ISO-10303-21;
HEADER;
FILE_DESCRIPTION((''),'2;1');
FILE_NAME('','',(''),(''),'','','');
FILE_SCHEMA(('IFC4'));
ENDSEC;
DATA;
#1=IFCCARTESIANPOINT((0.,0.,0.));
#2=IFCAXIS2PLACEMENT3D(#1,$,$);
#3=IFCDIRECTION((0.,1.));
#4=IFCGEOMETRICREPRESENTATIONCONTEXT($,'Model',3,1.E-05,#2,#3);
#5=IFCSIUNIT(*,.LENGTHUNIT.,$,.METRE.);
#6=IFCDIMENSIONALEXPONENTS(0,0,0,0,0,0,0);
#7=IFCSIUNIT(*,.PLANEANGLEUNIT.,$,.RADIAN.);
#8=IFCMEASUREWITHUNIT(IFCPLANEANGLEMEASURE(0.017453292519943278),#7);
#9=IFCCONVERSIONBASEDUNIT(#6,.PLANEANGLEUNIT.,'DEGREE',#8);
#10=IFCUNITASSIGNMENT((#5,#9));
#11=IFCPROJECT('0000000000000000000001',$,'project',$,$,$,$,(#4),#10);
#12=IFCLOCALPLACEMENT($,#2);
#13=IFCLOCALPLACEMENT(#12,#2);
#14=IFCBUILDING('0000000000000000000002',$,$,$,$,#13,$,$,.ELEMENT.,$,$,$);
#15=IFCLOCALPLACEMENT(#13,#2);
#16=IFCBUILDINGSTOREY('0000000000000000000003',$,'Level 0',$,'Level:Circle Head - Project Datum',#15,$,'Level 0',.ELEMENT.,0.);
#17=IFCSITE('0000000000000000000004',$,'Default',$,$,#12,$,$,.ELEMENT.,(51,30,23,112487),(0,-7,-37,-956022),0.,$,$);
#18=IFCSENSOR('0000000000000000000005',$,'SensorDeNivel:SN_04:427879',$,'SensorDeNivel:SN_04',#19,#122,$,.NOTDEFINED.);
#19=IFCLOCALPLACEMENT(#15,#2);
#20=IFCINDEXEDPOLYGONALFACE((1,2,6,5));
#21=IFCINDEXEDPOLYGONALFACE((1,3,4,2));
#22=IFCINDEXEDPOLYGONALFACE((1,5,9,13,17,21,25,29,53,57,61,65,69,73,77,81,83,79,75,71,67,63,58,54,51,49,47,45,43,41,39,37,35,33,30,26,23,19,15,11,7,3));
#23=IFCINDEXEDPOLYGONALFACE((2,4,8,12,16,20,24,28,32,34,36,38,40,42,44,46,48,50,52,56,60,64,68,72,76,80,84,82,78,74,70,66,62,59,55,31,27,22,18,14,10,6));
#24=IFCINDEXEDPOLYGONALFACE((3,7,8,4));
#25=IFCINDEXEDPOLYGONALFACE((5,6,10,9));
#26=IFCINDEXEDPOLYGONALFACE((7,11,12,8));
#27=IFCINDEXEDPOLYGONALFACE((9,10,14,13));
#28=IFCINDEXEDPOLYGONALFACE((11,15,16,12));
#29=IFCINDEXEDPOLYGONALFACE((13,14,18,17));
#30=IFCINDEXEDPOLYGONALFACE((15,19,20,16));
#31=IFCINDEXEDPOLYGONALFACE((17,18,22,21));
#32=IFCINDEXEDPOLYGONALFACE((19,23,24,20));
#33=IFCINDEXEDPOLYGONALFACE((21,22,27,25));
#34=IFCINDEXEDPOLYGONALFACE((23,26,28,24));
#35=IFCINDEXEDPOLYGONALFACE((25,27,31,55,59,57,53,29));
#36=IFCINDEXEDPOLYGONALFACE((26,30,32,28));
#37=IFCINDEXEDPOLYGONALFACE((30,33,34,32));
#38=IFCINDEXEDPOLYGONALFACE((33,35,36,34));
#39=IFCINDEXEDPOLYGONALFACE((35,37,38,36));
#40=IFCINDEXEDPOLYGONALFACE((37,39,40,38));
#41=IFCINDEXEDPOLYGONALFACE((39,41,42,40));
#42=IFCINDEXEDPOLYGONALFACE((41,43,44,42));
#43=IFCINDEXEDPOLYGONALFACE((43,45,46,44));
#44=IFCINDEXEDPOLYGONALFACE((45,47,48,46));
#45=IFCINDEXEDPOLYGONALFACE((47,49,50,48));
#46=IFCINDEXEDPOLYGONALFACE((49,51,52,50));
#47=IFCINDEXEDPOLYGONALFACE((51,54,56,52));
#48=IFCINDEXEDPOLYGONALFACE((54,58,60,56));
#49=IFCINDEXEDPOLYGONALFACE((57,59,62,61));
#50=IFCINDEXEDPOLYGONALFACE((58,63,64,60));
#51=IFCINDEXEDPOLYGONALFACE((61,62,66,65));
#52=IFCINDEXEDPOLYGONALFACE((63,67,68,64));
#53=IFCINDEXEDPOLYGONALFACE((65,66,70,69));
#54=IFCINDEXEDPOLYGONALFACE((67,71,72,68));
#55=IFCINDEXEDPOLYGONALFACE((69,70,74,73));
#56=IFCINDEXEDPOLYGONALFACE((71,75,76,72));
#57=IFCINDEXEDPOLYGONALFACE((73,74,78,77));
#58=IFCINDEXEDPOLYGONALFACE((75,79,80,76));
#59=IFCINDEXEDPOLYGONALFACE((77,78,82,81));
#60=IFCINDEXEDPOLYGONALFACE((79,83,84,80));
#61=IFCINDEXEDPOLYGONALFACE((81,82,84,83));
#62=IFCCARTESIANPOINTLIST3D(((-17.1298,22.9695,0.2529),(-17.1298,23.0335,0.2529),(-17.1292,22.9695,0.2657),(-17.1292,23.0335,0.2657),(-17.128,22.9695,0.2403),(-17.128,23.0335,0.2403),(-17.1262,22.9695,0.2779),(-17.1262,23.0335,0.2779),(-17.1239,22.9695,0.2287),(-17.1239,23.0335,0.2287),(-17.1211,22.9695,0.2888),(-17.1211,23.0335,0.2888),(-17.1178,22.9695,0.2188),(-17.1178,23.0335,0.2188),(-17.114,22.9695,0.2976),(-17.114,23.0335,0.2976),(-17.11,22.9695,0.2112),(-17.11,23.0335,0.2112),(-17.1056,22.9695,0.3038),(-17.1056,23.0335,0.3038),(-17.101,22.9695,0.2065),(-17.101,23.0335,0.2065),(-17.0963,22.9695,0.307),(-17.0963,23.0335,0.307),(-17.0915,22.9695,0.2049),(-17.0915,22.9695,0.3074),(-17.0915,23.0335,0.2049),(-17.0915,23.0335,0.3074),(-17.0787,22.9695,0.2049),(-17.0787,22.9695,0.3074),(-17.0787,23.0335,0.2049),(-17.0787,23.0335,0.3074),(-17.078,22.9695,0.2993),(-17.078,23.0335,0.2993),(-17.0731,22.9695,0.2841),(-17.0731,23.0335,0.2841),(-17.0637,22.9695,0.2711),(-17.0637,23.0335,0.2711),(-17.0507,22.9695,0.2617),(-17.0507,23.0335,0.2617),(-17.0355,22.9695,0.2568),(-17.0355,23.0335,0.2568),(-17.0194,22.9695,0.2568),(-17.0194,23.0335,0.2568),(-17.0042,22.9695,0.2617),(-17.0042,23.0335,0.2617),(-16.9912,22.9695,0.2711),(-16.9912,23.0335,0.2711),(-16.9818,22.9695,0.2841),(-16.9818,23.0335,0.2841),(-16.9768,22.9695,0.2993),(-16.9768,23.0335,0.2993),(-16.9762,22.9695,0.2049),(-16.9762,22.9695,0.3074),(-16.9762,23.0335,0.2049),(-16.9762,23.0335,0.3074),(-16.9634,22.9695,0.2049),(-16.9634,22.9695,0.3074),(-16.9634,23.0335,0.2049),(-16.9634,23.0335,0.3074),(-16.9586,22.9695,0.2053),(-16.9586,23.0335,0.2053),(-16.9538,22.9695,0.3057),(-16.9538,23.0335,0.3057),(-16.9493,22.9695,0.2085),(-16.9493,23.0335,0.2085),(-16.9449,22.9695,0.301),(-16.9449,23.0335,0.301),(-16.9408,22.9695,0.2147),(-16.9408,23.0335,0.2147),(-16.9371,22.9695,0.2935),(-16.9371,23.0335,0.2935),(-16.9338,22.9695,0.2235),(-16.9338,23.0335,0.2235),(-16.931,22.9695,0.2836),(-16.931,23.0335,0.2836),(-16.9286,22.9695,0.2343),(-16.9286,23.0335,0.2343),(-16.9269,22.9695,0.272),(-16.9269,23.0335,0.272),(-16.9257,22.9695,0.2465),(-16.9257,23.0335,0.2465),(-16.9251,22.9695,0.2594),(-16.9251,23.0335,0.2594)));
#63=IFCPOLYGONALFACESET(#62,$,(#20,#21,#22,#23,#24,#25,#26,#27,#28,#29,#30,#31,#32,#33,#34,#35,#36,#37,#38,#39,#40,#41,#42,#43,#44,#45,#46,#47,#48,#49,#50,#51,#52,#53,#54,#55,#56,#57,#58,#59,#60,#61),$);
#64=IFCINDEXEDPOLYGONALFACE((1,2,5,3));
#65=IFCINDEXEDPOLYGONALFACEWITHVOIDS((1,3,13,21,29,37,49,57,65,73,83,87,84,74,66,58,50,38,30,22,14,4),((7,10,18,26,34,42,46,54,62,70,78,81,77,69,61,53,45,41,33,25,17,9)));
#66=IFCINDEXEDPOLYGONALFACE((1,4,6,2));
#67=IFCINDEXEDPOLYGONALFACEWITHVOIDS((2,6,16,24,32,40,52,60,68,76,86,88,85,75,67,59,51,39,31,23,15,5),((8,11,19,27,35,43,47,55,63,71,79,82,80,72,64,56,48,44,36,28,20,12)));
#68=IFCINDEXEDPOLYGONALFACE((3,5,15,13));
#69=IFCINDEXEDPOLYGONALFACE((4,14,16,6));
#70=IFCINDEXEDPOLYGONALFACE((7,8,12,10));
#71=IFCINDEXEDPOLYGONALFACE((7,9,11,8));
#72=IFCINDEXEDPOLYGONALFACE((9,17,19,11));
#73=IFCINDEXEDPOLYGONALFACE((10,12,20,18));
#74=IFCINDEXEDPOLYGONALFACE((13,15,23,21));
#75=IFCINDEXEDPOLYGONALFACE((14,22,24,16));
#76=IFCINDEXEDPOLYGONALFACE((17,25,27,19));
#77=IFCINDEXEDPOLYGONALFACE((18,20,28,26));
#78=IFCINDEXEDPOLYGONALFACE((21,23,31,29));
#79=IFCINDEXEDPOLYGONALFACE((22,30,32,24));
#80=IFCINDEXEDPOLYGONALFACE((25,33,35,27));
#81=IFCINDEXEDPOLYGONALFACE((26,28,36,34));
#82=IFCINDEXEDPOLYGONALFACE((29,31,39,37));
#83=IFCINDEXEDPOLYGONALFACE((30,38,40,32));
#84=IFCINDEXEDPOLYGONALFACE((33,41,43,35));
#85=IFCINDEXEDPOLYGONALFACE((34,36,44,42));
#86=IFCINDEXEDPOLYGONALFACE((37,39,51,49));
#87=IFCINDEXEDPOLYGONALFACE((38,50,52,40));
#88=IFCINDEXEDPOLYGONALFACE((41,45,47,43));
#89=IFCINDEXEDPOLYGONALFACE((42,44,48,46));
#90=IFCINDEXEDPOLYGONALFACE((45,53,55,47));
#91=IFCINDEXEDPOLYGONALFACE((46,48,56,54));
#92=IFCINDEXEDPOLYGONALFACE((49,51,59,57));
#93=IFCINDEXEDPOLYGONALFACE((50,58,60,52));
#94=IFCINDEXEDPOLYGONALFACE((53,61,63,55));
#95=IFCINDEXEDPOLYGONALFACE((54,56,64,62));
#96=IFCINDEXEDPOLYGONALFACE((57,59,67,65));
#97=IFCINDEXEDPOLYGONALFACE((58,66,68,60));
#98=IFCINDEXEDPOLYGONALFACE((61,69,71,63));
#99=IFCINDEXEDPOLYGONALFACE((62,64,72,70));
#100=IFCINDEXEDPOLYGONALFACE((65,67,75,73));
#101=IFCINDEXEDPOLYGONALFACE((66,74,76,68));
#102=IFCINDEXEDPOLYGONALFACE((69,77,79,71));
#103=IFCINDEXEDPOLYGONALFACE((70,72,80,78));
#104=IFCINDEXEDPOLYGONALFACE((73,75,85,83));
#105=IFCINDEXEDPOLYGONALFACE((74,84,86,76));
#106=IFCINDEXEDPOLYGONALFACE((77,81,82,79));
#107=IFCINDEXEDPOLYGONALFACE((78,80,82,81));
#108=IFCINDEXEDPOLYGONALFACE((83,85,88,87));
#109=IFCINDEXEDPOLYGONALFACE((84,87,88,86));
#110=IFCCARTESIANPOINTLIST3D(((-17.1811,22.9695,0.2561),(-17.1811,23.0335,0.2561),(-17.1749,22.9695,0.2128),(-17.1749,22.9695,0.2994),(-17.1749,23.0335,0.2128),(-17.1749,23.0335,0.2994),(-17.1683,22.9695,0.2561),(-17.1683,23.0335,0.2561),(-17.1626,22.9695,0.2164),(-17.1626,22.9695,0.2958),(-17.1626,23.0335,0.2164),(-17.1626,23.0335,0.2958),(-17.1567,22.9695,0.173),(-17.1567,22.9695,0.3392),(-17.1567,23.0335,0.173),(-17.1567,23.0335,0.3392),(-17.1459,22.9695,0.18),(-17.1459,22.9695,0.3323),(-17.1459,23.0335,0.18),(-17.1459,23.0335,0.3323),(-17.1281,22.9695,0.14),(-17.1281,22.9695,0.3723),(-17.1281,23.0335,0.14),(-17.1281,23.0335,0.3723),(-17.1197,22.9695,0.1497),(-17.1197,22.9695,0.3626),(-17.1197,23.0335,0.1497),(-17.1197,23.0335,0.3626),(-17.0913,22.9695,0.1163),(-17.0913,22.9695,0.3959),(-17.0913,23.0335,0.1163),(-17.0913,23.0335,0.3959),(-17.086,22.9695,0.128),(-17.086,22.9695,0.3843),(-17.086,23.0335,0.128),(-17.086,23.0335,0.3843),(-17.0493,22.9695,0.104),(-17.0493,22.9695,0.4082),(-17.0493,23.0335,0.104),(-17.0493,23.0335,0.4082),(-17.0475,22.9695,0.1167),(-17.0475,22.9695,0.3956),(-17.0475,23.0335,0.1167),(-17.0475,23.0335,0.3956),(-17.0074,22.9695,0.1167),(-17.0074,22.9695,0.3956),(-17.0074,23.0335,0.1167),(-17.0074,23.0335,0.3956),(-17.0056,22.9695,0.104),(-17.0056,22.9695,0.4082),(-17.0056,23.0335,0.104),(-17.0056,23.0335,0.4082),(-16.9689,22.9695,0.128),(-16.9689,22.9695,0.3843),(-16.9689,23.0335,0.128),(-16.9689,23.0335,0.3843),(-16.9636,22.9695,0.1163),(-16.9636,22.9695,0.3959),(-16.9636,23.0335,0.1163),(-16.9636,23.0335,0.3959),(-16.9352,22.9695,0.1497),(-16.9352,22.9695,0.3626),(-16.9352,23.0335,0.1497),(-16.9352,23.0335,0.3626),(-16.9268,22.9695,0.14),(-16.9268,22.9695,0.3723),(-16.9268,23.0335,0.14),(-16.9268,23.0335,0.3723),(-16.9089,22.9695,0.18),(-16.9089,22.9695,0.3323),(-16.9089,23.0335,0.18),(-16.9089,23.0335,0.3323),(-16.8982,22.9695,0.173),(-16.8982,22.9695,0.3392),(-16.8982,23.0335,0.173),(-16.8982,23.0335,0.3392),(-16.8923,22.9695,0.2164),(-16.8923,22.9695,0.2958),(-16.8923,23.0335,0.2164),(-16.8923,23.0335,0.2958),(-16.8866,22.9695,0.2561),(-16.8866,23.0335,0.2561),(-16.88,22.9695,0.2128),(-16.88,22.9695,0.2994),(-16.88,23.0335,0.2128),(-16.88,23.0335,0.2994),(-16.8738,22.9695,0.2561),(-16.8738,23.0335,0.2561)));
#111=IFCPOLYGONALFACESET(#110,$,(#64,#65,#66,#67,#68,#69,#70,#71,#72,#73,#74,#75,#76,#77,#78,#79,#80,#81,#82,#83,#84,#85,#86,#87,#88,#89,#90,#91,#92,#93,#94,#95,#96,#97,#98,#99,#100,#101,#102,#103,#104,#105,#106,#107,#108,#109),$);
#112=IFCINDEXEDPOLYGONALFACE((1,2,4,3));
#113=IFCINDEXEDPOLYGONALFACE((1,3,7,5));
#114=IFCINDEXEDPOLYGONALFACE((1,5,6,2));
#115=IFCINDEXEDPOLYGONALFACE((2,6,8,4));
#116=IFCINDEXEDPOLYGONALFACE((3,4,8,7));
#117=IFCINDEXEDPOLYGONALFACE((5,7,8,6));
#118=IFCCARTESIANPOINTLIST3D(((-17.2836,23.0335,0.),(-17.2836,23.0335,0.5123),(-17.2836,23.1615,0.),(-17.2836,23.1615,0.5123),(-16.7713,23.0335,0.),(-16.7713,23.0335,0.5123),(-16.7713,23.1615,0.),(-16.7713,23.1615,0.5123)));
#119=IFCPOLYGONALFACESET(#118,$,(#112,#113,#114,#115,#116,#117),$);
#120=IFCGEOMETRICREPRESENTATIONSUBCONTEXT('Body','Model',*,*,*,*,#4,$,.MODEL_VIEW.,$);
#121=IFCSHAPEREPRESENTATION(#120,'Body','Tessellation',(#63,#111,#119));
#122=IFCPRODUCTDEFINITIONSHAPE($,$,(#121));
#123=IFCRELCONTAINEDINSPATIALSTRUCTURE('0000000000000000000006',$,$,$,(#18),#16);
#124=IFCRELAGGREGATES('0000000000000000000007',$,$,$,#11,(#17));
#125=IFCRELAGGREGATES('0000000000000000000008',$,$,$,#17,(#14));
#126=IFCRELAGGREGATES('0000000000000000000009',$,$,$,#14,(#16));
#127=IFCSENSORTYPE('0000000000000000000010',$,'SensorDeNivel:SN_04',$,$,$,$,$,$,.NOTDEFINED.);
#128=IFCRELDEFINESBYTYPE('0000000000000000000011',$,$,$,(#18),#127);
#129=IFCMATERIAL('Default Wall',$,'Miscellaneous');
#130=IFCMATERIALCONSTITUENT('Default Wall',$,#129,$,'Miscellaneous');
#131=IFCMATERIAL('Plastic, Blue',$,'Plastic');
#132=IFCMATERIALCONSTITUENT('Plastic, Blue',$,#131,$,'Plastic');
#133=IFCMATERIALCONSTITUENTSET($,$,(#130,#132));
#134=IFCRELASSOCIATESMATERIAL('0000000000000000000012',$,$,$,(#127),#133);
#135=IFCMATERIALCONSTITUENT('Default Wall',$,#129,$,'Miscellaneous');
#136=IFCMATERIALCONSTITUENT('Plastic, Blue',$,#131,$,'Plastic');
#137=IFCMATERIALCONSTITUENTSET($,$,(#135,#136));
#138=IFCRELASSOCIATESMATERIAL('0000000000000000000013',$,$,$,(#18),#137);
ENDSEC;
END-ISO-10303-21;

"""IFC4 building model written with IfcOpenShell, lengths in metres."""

from ifc_helpers import new_model, entity, si_unit, converted_unit, direction, frame, origin, place, context, subcontext, project, spatial, arc, indexed_curve, outline, extrude, source, transform, mapped, material, constituent, constituent_set, type_object, type_shapes, element, save


model = new_model("IFC4")

# Units and contexts
model_context = context("Model", 3, precision=1e-05, world=origin(), true_north=direction((0.0, 1.0)))
body_context = subcontext(model_context, "Body", "Model", "MODEL_VIEW")
ifc_project = project(units=[si_unit("LENGTHUNIT", "METRE"), converted_unit("PLANEANGLEUNIT", "DEGREE", entity("IfcPlaneAngleMeasure", 0.017453292519943278), si_unit("PLANEANGLEUNIT", "RADIAN"), dimensions=[0, 0, 0, 0, 0, 0, 0])], contexts=[model_context])

# Site, building, storey
site_placement = place(None, origin())
site = spatial("IfcSite", under=ifc_project, at=site_placement, Name="Default", CompositionType="ELEMENT", RefLatitude=(51, 30, 23, 112487), RefLongitude=(0, -7, -37, -956022), RefElevation=0.0)
building_placement = place(site_placement, origin())
building = spatial("IfcBuilding", under=site, at=building_placement, CompositionType="ELEMENT")
storey_placement = place(building_placement, origin())
storey = spatial("IfcBuildingStorey", under=building, at=storey_placement, Name="Level 0", ObjectType="Level:Circle Head - Project Datum", LongName="Level 0", CompositionType="ELEMENT", Elevation=0.0)

# Sensor
ifc_material_1 = material(Name="Default Wall", Category="Miscellaneous")
ifc_material_2 = material(Name="Plastic, Blue", Category="Plastic")
ifc_constituent_1 = constituent(ifc_material_1, Name="Default Wall", Category="Miscellaneous")
ifc_constituent_2 = constituent(ifc_material_2, Name="Plastic, Blue", Category="Plastic")
ifc_constituent_set_1 = constituent_set(constituents=[ifc_constituent_1, ifc_constituent_2])
ifc_constituent_3 = constituent(ifc_material_1, Name="Default Wall", Category="Miscellaneous")
ifc_constituent_4 = constituent(ifc_material_2, Name="Plastic, Blue", Category="Plastic")
ifc_constituent_set_2 = constituent_set(constituents=[ifc_constituent_3, ifc_constituent_4])
sensor_type_1 = type_object("IfcSensorType", Name="SensorDeNivel:SN_04", PredefinedType="NOTDEFINED", material=ifc_constituent_set_2)
shared_shape_1 = source(origin(), body_context, "Body", "SweptSolid", [
    extrude(outline(indexed_curve([(0.0512, -0.0556), (0.064, -0.0556), (0.0736, -0.054), (0.0825, -0.0493), (0.0903, -0.0417), (0.0965, -0.0318), (0.1006, -0.0202), (0.1024, -0.0076), (0.1018, 0.0052), (0.0988, 0.0174), (0.0936, 0.0283), (0.0866, 0.037), (0.0782, 0.0432), (0.0689, 0.0464), (0.064, 0.0468), (0.0512, 0.0468), (0.0506, 0.0388), (0.0456, 0.0236), (0.0362, 0.0106), (0.0233, 0.0012), (0.008, -0.0038), (-0.008, -0.0038), (-0.0233, 0.0012), (-0.0362, 0.0106), (-0.0456, 0.0236), (-0.0506, 0.0388), (-0.0512, 0.0468), (-0.064, 0.0468), (-0.0736, 0.0452), (-0.0825, 0.0405), (-0.0903, 0.0329), (-0.0965, 0.023), (-0.1006, 0.0114), (-0.1024, -0.0012), (-0.1018, -0.014), (-0.0988, -0.0262), (-0.0936, -0.0371), (-0.0866, -0.0458), (-0.0782, -0.052), (-0.0689, -0.0552), (-0.064, -0.0556), (-0.0512, -0.0556), (0.0512, -0.0556)], self_intersect=False)), frame((0.0, -0.1281, 0.2605), z_axis=(0.0, 1.0, 0.0), x_axis=(-1.0, 0.0, 0.0)), (0.0, 0.0, 1.0), 0.064),
    extrude(outline(indexed_curve([(-0.1537, 0.0), (0.0, -0.1537), (0.1537, 0.0), (0.0, 0.1537)], segments=[arc(1, 2, 3), arc(3, 4, 1)], self_intersect=False), holes=[indexed_curve([(-0.1409, 0.0), (0.0, 0.1409), (0.1409, 0.0), (0.0, -0.1409)], segments=[arc(1, 2, 3), arc(3, 4, 1)], self_intersect=False)]), frame((0.0, -0.1281, 0.2561), z_axis=(0.0, 1.0, 0.0), x_axis=(1.0, 0.0, 0.0)), (0.0, 0.0, 1.0), 0.064),
    extrude(outline(indexed_curve([(-0.2561, -0.064), (0.2561, -0.064), (0.2561, 0.064), (-0.2561, 0.064), (-0.2561, -0.064)], self_intersect=False)), frame((0.0, 0.0, 0.0), z_axis=(0.0, 0.0, 1.0), x_axis=(-1.0, 0.0, 0.0)), (0.0, 0.0, 1.0), 0.5123),
])
type_shapes(sensor_type_1, [shared_shape_1])
sensor_1_placement = place(storey_placement, frame((-17.0274, 23.0975, 0.0)))
element("IfcSensor", 1, at=sensor_1_placement, inside=storey, type_object=sensor_type_1, material=ifc_constituent_set_1, Name="SensorDeNivel:SN_04:427879", ObjectType="SensorDeNivel:SN_04", PredefinedType="NOTDEFINED", context=body_context, shape_type="MappedRepresentation", body=[
    mapped(shared_shape_1, transform((0.0, 0.0, 0.0), scale=1.0)),
])

save(model, "model.ifc")
